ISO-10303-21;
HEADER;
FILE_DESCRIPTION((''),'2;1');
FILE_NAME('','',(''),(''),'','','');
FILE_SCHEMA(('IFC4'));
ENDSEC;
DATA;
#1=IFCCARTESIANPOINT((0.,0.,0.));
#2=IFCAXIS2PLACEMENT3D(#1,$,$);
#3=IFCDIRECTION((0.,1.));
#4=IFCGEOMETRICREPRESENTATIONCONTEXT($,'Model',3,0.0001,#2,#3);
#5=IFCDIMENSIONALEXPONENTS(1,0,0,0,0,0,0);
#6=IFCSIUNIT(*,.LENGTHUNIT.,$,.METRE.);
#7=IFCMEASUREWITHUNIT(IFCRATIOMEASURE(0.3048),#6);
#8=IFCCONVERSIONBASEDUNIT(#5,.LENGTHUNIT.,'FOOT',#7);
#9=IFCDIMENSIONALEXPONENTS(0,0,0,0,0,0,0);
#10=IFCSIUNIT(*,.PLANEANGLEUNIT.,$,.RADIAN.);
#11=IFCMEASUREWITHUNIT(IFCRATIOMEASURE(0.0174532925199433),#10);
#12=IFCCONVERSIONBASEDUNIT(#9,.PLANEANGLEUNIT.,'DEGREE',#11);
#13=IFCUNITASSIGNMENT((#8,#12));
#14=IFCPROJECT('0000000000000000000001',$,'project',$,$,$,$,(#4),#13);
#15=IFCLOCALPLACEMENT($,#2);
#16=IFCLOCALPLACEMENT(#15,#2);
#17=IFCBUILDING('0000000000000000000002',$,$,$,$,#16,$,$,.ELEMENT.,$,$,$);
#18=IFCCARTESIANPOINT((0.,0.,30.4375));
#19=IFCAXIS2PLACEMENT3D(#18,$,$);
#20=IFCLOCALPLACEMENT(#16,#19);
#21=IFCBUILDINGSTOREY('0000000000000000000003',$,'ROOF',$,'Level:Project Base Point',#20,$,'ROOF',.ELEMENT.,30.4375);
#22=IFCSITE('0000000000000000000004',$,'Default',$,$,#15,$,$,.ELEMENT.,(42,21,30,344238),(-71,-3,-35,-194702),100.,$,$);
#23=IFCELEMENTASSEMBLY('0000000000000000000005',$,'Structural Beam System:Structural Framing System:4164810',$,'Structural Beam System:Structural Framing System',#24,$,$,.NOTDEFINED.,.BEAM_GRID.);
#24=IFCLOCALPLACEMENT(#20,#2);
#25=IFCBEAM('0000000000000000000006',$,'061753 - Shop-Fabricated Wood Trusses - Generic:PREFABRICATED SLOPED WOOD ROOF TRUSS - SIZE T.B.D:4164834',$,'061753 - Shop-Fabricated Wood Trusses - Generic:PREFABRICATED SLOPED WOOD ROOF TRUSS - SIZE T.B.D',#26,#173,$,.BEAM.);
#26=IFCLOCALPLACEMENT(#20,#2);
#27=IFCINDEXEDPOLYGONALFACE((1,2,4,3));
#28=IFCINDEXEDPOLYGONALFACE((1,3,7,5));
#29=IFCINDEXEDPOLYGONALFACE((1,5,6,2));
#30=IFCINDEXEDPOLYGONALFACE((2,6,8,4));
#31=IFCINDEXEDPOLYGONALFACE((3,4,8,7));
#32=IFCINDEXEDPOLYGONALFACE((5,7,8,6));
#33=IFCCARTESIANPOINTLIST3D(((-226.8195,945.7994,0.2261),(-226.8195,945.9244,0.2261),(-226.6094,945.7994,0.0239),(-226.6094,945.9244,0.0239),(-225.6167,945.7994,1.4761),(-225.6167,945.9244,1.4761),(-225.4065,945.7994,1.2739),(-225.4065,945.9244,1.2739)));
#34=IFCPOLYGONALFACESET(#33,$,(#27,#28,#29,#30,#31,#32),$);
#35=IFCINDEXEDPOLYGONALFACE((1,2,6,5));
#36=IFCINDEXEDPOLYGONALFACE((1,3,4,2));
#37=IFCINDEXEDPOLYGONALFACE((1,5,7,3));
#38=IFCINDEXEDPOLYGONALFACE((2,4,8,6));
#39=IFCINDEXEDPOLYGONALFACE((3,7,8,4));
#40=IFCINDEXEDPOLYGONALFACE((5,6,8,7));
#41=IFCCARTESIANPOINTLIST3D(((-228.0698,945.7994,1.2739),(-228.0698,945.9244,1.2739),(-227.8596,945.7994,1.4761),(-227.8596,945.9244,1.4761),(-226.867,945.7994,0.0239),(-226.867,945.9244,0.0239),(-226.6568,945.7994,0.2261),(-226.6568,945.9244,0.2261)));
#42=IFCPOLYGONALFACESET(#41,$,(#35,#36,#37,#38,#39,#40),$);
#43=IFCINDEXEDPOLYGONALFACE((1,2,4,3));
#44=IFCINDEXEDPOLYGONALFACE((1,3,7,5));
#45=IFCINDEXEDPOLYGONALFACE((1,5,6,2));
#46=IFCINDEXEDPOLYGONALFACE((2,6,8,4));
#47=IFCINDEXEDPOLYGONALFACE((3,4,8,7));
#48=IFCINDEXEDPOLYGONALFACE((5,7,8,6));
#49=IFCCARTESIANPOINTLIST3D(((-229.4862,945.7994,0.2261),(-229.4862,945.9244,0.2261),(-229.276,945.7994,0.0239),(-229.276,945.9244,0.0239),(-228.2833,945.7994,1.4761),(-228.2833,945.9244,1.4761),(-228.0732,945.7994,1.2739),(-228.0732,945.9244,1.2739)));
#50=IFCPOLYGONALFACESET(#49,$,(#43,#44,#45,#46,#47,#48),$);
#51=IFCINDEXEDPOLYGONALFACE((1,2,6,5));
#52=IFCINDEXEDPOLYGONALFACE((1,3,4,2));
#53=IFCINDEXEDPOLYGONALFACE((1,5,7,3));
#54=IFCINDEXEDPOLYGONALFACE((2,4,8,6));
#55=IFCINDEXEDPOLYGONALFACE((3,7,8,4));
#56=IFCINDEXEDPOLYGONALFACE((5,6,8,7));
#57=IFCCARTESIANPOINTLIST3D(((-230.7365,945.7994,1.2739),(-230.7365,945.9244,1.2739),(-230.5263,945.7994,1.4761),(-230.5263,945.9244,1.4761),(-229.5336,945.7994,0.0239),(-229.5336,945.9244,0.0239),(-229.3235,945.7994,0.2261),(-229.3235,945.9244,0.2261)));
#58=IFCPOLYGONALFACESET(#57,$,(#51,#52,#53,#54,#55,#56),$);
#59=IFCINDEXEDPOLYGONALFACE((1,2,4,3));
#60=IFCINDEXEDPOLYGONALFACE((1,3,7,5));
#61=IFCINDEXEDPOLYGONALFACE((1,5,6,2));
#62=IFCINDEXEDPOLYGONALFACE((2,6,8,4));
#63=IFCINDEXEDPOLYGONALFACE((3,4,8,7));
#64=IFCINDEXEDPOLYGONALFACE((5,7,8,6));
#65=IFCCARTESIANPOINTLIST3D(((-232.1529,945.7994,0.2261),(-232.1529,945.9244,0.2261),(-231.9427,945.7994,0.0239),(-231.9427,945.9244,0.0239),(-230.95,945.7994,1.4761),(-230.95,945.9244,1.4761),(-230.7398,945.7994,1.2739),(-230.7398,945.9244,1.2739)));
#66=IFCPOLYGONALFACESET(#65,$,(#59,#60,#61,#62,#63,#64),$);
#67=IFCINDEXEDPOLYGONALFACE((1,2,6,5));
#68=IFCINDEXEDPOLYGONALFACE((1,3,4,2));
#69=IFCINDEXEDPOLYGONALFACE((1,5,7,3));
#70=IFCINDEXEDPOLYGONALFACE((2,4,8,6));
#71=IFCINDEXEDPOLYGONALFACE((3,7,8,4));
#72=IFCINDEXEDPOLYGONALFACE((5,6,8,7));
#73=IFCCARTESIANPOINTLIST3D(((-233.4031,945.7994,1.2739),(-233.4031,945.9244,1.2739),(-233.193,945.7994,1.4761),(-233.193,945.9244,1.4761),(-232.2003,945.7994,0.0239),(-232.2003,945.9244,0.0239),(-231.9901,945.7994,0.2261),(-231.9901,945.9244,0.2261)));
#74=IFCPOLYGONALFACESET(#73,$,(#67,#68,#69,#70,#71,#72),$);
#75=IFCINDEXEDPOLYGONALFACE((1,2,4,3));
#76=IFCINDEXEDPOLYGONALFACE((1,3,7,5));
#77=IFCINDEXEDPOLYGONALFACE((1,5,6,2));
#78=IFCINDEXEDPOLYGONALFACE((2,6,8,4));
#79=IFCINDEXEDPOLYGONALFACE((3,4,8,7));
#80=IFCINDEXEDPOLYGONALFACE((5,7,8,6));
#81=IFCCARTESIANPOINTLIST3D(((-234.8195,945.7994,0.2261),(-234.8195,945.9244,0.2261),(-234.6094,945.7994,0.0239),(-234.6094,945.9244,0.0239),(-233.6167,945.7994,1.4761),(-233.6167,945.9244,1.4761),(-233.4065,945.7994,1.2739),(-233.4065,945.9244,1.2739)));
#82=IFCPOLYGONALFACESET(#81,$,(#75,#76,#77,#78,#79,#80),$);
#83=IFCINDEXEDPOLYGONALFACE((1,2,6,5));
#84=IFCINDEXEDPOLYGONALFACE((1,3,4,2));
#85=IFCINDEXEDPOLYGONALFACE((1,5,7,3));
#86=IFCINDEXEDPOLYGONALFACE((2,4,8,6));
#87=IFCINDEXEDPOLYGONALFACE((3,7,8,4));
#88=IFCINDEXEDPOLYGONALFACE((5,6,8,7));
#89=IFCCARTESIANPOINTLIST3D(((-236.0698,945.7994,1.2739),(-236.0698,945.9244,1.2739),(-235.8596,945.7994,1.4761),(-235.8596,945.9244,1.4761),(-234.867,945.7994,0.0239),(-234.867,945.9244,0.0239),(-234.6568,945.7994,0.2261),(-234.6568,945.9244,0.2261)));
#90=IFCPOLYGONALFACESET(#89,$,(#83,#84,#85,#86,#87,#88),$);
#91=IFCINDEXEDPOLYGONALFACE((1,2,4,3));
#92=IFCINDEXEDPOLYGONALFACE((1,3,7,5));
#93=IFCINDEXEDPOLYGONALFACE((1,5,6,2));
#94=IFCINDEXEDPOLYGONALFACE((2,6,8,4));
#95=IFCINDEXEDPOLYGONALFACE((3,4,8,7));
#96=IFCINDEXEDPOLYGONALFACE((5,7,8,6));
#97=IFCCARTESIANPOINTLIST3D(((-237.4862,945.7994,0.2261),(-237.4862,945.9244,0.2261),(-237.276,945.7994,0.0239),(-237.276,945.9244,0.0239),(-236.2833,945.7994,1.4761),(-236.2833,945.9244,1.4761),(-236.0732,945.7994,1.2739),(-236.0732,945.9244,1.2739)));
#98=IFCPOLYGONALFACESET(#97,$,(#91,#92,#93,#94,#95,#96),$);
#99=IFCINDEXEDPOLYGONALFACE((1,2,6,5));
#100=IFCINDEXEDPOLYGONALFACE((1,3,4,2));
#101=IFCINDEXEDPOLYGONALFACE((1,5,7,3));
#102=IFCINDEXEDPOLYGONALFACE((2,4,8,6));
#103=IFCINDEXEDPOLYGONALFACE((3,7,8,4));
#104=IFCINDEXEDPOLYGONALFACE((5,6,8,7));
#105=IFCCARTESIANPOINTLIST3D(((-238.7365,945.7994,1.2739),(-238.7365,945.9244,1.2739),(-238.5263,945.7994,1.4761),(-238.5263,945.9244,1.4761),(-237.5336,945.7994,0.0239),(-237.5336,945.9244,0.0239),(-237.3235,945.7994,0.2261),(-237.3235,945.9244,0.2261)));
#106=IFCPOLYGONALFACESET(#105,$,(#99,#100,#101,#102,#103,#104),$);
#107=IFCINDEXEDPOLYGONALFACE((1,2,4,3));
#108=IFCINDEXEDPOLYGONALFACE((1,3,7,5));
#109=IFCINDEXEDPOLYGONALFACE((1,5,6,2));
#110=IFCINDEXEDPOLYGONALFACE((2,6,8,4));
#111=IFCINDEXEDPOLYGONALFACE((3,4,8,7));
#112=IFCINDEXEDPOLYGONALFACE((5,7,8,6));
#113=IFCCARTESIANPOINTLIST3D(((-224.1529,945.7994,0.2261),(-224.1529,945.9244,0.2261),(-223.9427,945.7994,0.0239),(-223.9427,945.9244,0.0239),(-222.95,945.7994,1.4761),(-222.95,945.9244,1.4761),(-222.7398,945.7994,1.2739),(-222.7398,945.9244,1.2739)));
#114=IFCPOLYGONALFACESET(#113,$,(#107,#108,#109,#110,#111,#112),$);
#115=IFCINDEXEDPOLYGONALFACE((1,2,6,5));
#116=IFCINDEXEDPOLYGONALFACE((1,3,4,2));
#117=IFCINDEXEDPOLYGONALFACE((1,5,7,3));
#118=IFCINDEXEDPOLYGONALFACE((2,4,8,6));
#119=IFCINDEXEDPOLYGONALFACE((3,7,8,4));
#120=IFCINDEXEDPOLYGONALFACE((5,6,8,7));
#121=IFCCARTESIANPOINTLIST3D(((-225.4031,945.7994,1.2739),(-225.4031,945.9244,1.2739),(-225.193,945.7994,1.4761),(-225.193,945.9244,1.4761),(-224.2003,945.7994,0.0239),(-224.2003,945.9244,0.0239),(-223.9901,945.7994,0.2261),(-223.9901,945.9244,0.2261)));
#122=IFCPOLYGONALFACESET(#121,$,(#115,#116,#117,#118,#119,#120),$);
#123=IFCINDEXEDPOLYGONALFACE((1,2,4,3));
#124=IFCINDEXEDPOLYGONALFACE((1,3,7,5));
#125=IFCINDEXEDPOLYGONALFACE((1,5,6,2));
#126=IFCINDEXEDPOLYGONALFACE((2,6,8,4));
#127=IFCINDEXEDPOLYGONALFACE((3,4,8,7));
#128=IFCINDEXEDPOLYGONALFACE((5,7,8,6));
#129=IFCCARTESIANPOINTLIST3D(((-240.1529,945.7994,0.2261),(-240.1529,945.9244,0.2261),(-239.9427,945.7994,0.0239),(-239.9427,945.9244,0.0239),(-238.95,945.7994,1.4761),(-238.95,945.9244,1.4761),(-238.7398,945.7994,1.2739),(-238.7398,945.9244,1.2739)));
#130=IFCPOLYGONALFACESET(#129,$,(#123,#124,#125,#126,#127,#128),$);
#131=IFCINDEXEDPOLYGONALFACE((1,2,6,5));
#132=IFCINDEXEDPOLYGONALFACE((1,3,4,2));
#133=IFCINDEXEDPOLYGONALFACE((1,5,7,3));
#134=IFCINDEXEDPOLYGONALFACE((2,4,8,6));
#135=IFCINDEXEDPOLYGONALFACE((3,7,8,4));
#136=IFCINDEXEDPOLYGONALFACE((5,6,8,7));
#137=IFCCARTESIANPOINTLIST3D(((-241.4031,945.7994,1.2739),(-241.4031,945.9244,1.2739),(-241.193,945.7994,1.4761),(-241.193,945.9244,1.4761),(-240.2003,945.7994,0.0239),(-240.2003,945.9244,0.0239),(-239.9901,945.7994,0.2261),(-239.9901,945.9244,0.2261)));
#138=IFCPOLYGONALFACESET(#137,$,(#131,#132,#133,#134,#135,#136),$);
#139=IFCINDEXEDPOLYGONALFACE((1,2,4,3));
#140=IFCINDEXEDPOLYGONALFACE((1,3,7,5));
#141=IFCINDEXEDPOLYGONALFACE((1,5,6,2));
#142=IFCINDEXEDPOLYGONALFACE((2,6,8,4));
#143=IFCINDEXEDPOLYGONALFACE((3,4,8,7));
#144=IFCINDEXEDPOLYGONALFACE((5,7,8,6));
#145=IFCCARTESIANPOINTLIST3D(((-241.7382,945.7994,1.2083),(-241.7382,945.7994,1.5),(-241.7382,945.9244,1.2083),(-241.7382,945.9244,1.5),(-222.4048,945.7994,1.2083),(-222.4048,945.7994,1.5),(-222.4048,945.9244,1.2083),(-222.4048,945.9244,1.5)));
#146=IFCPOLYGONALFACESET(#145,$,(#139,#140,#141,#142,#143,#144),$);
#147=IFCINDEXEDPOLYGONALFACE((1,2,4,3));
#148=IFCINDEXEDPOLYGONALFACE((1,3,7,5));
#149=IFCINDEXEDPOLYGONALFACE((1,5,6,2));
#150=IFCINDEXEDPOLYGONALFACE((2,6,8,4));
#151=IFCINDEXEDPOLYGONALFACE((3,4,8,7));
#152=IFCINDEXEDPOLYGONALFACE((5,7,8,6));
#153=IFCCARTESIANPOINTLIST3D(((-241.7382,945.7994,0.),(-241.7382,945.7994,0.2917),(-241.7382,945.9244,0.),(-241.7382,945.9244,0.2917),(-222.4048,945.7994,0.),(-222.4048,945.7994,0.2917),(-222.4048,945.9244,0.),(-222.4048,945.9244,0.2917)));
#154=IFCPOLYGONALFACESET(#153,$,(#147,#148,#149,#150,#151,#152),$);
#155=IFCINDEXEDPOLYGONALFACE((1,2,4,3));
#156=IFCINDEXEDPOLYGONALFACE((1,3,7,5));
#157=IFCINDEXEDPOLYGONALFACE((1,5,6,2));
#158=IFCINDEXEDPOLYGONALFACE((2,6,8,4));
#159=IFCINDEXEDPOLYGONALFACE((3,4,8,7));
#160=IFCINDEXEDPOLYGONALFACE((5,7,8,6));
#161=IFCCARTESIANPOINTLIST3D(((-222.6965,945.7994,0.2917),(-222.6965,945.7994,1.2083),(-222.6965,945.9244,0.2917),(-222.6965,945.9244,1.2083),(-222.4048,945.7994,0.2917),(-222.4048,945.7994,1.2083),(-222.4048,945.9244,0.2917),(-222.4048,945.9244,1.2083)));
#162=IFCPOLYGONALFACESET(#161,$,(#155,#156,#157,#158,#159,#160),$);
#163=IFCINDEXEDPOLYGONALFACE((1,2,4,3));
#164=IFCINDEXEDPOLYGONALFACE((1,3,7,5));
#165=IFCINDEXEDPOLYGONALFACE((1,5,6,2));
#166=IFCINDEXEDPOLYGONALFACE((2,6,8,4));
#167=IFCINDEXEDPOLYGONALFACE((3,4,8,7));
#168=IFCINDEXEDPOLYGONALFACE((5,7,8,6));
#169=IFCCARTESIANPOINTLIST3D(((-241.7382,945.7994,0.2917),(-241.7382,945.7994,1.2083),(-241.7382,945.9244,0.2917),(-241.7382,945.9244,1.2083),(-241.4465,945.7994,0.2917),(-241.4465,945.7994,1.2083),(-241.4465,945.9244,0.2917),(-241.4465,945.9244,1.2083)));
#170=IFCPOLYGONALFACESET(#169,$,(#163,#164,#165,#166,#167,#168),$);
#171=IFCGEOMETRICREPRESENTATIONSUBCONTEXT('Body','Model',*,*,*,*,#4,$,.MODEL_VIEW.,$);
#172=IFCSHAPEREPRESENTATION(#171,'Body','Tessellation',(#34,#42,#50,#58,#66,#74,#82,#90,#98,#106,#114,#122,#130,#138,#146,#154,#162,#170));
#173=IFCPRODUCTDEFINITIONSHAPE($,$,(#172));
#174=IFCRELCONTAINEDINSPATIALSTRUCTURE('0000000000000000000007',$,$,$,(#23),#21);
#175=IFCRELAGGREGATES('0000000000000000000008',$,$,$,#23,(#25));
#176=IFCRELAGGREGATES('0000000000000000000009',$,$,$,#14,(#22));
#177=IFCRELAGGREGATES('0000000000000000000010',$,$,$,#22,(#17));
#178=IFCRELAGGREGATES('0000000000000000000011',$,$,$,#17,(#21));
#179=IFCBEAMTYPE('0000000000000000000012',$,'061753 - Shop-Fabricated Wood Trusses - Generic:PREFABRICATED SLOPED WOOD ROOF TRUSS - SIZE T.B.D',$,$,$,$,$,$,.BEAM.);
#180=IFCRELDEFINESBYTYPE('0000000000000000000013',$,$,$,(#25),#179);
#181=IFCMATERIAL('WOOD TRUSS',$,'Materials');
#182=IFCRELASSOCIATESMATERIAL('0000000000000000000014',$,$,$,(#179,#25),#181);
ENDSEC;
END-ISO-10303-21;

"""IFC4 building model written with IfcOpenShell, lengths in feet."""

from ifc_helpers import new_model, entity, si_unit, converted_unit, direction, frame, frame_2d, origin, origin_2d_with_axis, place, context, subcontext, project, spatial, rectangle, extrude, source, transform, mapped, material, material_profile, profile_set, profile_usage, type_object, type_shapes, element, aggregate, save


model = new_model("IFC4")

# Units and contexts
model_context = context("Model", 3, precision=0.0001, world=origin(), true_north=direction((0.0, 1.0)))
body_context = subcontext(model_context, "Body", "Model", "MODEL_VIEW")
ifc_project = project(units=[converted_unit("LENGTHUNIT", "FOOT", entity("IfcRatioMeasure", 0.3048), si_unit("LENGTHUNIT", "METRE"), dimensions=[1, 0, 0, 0, 0, 0, 0]), converted_unit("PLANEANGLEUNIT", "DEGREE", entity("IfcRatioMeasure", 0.0174532925199433), si_unit("PLANEANGLEUNIT", "RADIAN"), dimensions=[0, 0, 0, 0, 0, 0, 0])], contexts=[model_context])

# Site, building, storey
site_placement = place(None, origin())
site = spatial("IfcSite", under=ifc_project, at=site_placement, Name="Default", CompositionType="ELEMENT", RefLatitude=(42, 21, 30, 344238), RefLongitude=(-71, -3, -35, -194702), RefElevation=100.0)
building_placement = place(site_placement, origin())
building = spatial("IfcBuilding", under=site, at=building_placement, CompositionType="ELEMENT")
storey_placement = place(building_placement, frame((0.0, 0.0, 30.4375)))
storey = spatial("IfcBuildingStorey", under=building, at=storey_placement, Name="ROOF", ObjectType="Level:Project Base Point", LongName="ROOF", CompositionType="ELEMENT", Elevation=30.4375)

# Element assembly, beam
assembly_1_placement = place(storey_placement, origin())
assembly_1 = element("IfcElementAssembly", 1, at=assembly_1_placement, inside=storey, Name="Structural Beam System:Structural Framing System:4164810", ObjectType="Structural Beam System:Structural Framing System", AssemblyPlace="NOTDEFINED", PredefinedType="BEAM_GRID")
ifc_material_1 = material(Name="WOOD TRUSS", Category="Materials")
ifc_material_profile_1 = material_profile(ifc_material_1, rectangle(XDim=1.7347, YDim=0.125, at=origin_2d_with_axis()), Name="PREFABRICATED SLOPED WOOD ROOF TRUSS - SIZE T.B.D")
ifc_material_profile_2 = material_profile(ifc_material_1, rectangle(XDim=1.7347, YDim=0.125, at=frame_2d((0.0, 0.0), x_axis=(1.0, 0.0))), Name="PREFABRICATED SLOPED WOOD ROOF TRUSS - SIZE T.B.D")
ifc_material_profile_3 = material_profile(ifc_material_1, rectangle(XDim=1.7347, YDim=0.125, at=origin_2d_with_axis()), Name="PREFABRICATED SLOPED WOOD ROOF TRUSS - SIZE T.B.D")
ifc_material_profile_4 = material_profile(ifc_material_1, rectangle(XDim=1.7347, YDim=0.125, at=origin_2d_with_axis()), Name="PREFABRICATED SLOPED WOOD ROOF TRUSS - SIZE T.B.D")
ifc_material_profile_5 = material_profile(ifc_material_1, rectangle(XDim=1.7347, YDim=0.125, at=frame_2d((0.0, 0.0), x_axis=(1.0, 0.0))), Name="PREFABRICATED SLOPED WOOD ROOF TRUSS - SIZE T.B.D")
ifc_material_profile_6 = material_profile(ifc_material_1, rectangle(XDim=1.7347, YDim=0.125, at=frame_2d((0.0, 0.0), x_axis=(1.0, 0.0))), Name="PREFABRICATED SLOPED WOOD ROOF TRUSS - SIZE T.B.D")
ifc_material_profile_7 = material_profile(ifc_material_1, rectangle(XDim=1.7347, YDim=0.125, at=frame_2d((0.0, 0.0), x_axis=(1.0, 0.0))), Name="PREFABRICATED SLOPED WOOD ROOF TRUSS - SIZE T.B.D")
ifc_material_profile_8 = material_profile(ifc_material_1, rectangle(XDim=1.7347, YDim=0.125, at=frame_2d((0.0, 0.0), x_axis=(1.0, 0.0))), Name="PREFABRICATED SLOPED WOOD ROOF TRUSS - SIZE T.B.D")
ifc_material_profile_9 = material_profile(ifc_material_1, rectangle(XDim=1.7347, YDim=0.125, at=origin_2d_with_axis()), Name="PREFABRICATED SLOPED WOOD ROOF TRUSS - SIZE T.B.D")
ifc_material_profile_10 = material_profile(ifc_material_1, rectangle(XDim=1.7347, YDim=0.125, at=frame_2d((0.0, 0.0), x_axis=(1.0, 0.0))), Name="PREFABRICATED SLOPED WOOD ROOF TRUSS - SIZE T.B.D")
ifc_material_profile_11 = material_profile(ifc_material_1, rectangle(XDim=0.2917, YDim=0.125, at=frame_2d((0.0, 0.0), x_axis=(1.0, 0.0))), Name="PREFABRICATED SLOPED WOOD ROOF TRUSS - SIZE T.B.D")
ifc_material_profile_12 = material_profile(ifc_material_1, rectangle(XDim=0.2917, YDim=0.125, at=frame_2d((0.0, 0.0), x_axis=(1.0, 0.0))), Name="PREFABRICATED SLOPED WOOD ROOF TRUSS - SIZE T.B.D")
ifc_material_profile_13 = material_profile(ifc_material_1, rectangle(XDim=0.9167, YDim=0.125, at=frame_2d((0.0, 0.0), x_axis=(1.0, 0.0))), Name="PREFABRICATED SLOPED WOOD ROOF TRUSS - SIZE T.B.D")
ifc_material_profile_14 = material_profile(ifc_material_1, rectangle(XDim=0.9167, YDim=0.125, at=frame_2d((0.0, 0.0), x_axis=(1.0, 0.0))), Name="PREFABRICATED SLOPED WOOD ROOF TRUSS - SIZE T.B.D")
ifc_profile_set_1 = profile_set([ifc_material_profile_1, ifc_material_profile_2, ifc_material_profile_3, ifc_material_profile_4, ifc_material_profile_5, ifc_material_profile_6, ifc_material_profile_7, ifc_material_profile_8, ifc_material_profile_9, ifc_material_profile_10, ifc_material_profile_11, ifc_material_profile_12, ifc_material_profile_13, ifc_material_profile_14], Name="PREFABRICATED SLOPED WOOD ROOF TRUSS - SIZE T.B.D")
beam_type_1 = type_object("IfcBeamType", Name="061753 - Shop-Fabricated Wood Trusses - Generic:PREFABRICATED SLOPED WOOD ROOF TRUSS - SIZE T.B.D", PredefinedType="BEAM", material=ifc_profile_set_1)
shared_shape_1 = source(origin(), body_context, "Body", "SweptSolid", [
    extrude(rectangle(XDim=1.7347, YDim=0.125, at=frame_2d((0.0, 0.0), x_axis=(1.0, 0.0))), frame((5.8534, 0.0, 0.1011), z_axis=(0.720569, 0.0, -0.693383), x_axis=(0.693383, 0.0, 0.720569)), (0.0, 0.0, 1.0), 0.2917),
    extrude(rectangle(XDim=1.7347, YDim=0.125, at=frame_2d((0.0, 0.0), x_axis=(1.0, 0.0))), frame((4.6031, 0.0, -0.1011), z_axis=(0.720569, 0.0, 0.693383), x_axis=(0.693383, 0.0, -0.720569)), (0.0, 0.0, 1.0), 0.2917),
    extrude(rectangle(XDim=1.7347, YDim=0.125, at=frame_2d((0.0, 0.0), x_axis=(1.0, 0.0))), frame((3.1867, 0.0, 0.1011), z_axis=(0.720569, 0.0, -0.693383), x_axis=(0.693383, 0.0, 0.720569)), (0.0, 0.0, 1.0), 0.2917),
    extrude(rectangle(XDim=1.7347, YDim=0.125, at=frame_2d((0.0, 0.0), x_axis=(1.0, 0.0))), frame((1.9364, 0.0, -0.1011), z_axis=(0.720569, 0.0, 0.693383), x_axis=(0.693383, 0.0, -0.720569)), (0.0, 0.0, 1.0), 0.2917),
    extrude(rectangle(XDim=1.7347, YDim=0.125, at=frame_2d((0.0, 0.0), x_axis=(1.0, 0.0))), frame((0.5201, 0.0, 0.1011), z_axis=(0.720569, 0.0, -0.693383), x_axis=(0.693383, 0.0, 0.720569)), (0.0, 0.0, 1.0), 0.2917),
    extrude(rectangle(XDim=1.7347, YDim=0.125, at=origin_2d_with_axis()), frame((-0.7302, 0.0, -0.1011), z_axis=(0.720569, 0.0, 0.693383), x_axis=(0.693383, 0.0, -0.720569)), (0.0, 0.0, 1.0), 0.2917),
    extrude(rectangle(XDim=1.7347, YDim=0.125, at=frame_2d((0.0, 0.0), x_axis=(1.0, 0.0))), frame((-2.1466, 0.0, 0.1011), z_axis=(0.720569, 0.0, -0.693383), x_axis=(0.693383, 0.0, 0.720569)), (0.0, 0.0, 1.0), 0.2917),
    extrude(rectangle(XDim=1.7347, YDim=0.125, at=frame_2d((0.0, 0.0), x_axis=(1.0, 0.0))), frame((-3.3969, 0.0, -0.1011), z_axis=(0.720569, 0.0, 0.693383), x_axis=(0.693383, 0.0, -0.720569)), (0.0, 0.0, 1.0), 0.2917),
    extrude(rectangle(XDim=1.7347, YDim=0.125, at=origin_2d_with_axis()), frame((-4.8133, 0.0, 0.1011), z_axis=(0.720569, 0.0, -0.693383), x_axis=(0.693383, 0.0, 0.720569)), (0.0, 0.0, 1.0), 0.2917),
    extrude(rectangle(XDim=1.7347, YDim=0.125, at=frame_2d((0.0, 0.0), x_axis=(1.0, 0.0))), frame((-6.0636, 0.0, -0.1011), z_axis=(0.720569, 0.0, 0.693383), x_axis=(0.693383, 0.0, -0.720569)), (0.0, 0.0, 1.0), 0.2917),
    extrude(rectangle(XDim=1.7347, YDim=0.125, at=frame_2d((0.0, 0.0), x_axis=(1.0, 0.0))), frame((8.5201, 0.0, 0.1011), z_axis=(0.720569, 0.0, -0.693383), x_axis=(0.693383, 0.0, 0.720569)), (0.0, 0.0, 1.0), 0.2917),
    extrude(rectangle(XDim=1.7347, YDim=0.125, at=origin_2d_with_axis()), frame((7.2698, 0.0, -0.1011), z_axis=(0.720569, 0.0, 0.693383), x_axis=(0.693383, 0.0, -0.720569)), (0.0, 0.0, 1.0), 0.2917),
    extrude(rectangle(XDim=1.7347, YDim=0.125, at=frame_2d((0.0, 0.0), x_axis=(1.0, 0.0))), frame((-7.4799, 0.0, 0.1011), z_axis=(0.720569, 0.0, -0.693383), x_axis=(0.693383, 0.0, 0.720569)), (0.0, 0.0, 1.0), 0.2917),
    extrude(rectangle(XDim=1.7347, YDim=0.125, at=origin_2d_with_axis()), frame((-8.7302, 0.0, -0.1011), z_axis=(0.720569, 0.0, 0.693383), x_axis=(0.693383, 0.0, -0.720569)), (0.0, 0.0, 1.0), 0.2917),
    extrude(rectangle(XDim=0.2917, YDim=0.125, at=frame_2d((0.0, 0.0), x_axis=(1.0, 0.0))), frame((-9.6667, 0.0, 0.6042), z_axis=(1.0, 0.0, 0.0), x_axis=(0.0, 0.0, -1.0)), (0.0, 0.0, 1.0), 19.3333),
    extrude(rectangle(XDim=0.2917, YDim=0.125, at=frame_2d((0.0, 0.0), x_axis=(1.0, 0.0))), frame((-9.6667, 0.0, -0.6042), z_axis=(1.0, 0.0, 0.0), x_axis=(0.0, 0.0, -1.0)), (0.0, 0.0, 1.0), 19.3333),
    extrude(rectangle(XDim=0.9167, YDim=0.125, at=frame_2d((0.0, 0.0), x_axis=(1.0, 0.0))), frame((9.375, 0.0, 0.0), z_axis=(1.0, 0.0, 0.0), x_axis=(0.0, 0.0, -1.0)), (0.0, 0.0, 1.0), 0.2917),
    extrude(rectangle(XDim=0.9167, YDim=0.125, at=frame_2d((0.0, 0.0), x_axis=(1.0, 0.0))), frame((-9.6667, 0.0, 0.0), z_axis=(1.0, 0.0, 0.0), x_axis=(0.0, 0.0, -1.0)), (0.0, 0.0, 1.0), 0.2917),
])
type_shapes(beam_type_1, [shared_shape_1])
ifc_profile_usage_1 = profile_usage(ifc_profile_set_1, cardinal=8)
beam_1_placement = place(assembly_1_placement, frame((-232.0715, 945.8619, 0.75)))
beam_1 = element("IfcBeam", 2, at=beam_1_placement, type_object=beam_type_1, material=ifc_profile_usage_1, Name="061753 - Shop-Fabricated Wood Trusses - Generic:PREFABRICATED SLOPED WOOD ROOF TRUSS - SIZE T.B.D:4164834", ObjectType="061753 - Shop-Fabricated Wood Trusses - Generic:PREFABRICATED SLOPED WOOD ROOF TRUSS - SIZE T.B.D", PredefinedType="BEAM", context=body_context, shape_type="MappedRepresentation", body=[
    mapped(shared_shape_1, transform((0.0, 0.0, 0.0), scale=1.0)),
])
aggregate(assembly_1, [beam_1])

save(model, "model.ifc")
